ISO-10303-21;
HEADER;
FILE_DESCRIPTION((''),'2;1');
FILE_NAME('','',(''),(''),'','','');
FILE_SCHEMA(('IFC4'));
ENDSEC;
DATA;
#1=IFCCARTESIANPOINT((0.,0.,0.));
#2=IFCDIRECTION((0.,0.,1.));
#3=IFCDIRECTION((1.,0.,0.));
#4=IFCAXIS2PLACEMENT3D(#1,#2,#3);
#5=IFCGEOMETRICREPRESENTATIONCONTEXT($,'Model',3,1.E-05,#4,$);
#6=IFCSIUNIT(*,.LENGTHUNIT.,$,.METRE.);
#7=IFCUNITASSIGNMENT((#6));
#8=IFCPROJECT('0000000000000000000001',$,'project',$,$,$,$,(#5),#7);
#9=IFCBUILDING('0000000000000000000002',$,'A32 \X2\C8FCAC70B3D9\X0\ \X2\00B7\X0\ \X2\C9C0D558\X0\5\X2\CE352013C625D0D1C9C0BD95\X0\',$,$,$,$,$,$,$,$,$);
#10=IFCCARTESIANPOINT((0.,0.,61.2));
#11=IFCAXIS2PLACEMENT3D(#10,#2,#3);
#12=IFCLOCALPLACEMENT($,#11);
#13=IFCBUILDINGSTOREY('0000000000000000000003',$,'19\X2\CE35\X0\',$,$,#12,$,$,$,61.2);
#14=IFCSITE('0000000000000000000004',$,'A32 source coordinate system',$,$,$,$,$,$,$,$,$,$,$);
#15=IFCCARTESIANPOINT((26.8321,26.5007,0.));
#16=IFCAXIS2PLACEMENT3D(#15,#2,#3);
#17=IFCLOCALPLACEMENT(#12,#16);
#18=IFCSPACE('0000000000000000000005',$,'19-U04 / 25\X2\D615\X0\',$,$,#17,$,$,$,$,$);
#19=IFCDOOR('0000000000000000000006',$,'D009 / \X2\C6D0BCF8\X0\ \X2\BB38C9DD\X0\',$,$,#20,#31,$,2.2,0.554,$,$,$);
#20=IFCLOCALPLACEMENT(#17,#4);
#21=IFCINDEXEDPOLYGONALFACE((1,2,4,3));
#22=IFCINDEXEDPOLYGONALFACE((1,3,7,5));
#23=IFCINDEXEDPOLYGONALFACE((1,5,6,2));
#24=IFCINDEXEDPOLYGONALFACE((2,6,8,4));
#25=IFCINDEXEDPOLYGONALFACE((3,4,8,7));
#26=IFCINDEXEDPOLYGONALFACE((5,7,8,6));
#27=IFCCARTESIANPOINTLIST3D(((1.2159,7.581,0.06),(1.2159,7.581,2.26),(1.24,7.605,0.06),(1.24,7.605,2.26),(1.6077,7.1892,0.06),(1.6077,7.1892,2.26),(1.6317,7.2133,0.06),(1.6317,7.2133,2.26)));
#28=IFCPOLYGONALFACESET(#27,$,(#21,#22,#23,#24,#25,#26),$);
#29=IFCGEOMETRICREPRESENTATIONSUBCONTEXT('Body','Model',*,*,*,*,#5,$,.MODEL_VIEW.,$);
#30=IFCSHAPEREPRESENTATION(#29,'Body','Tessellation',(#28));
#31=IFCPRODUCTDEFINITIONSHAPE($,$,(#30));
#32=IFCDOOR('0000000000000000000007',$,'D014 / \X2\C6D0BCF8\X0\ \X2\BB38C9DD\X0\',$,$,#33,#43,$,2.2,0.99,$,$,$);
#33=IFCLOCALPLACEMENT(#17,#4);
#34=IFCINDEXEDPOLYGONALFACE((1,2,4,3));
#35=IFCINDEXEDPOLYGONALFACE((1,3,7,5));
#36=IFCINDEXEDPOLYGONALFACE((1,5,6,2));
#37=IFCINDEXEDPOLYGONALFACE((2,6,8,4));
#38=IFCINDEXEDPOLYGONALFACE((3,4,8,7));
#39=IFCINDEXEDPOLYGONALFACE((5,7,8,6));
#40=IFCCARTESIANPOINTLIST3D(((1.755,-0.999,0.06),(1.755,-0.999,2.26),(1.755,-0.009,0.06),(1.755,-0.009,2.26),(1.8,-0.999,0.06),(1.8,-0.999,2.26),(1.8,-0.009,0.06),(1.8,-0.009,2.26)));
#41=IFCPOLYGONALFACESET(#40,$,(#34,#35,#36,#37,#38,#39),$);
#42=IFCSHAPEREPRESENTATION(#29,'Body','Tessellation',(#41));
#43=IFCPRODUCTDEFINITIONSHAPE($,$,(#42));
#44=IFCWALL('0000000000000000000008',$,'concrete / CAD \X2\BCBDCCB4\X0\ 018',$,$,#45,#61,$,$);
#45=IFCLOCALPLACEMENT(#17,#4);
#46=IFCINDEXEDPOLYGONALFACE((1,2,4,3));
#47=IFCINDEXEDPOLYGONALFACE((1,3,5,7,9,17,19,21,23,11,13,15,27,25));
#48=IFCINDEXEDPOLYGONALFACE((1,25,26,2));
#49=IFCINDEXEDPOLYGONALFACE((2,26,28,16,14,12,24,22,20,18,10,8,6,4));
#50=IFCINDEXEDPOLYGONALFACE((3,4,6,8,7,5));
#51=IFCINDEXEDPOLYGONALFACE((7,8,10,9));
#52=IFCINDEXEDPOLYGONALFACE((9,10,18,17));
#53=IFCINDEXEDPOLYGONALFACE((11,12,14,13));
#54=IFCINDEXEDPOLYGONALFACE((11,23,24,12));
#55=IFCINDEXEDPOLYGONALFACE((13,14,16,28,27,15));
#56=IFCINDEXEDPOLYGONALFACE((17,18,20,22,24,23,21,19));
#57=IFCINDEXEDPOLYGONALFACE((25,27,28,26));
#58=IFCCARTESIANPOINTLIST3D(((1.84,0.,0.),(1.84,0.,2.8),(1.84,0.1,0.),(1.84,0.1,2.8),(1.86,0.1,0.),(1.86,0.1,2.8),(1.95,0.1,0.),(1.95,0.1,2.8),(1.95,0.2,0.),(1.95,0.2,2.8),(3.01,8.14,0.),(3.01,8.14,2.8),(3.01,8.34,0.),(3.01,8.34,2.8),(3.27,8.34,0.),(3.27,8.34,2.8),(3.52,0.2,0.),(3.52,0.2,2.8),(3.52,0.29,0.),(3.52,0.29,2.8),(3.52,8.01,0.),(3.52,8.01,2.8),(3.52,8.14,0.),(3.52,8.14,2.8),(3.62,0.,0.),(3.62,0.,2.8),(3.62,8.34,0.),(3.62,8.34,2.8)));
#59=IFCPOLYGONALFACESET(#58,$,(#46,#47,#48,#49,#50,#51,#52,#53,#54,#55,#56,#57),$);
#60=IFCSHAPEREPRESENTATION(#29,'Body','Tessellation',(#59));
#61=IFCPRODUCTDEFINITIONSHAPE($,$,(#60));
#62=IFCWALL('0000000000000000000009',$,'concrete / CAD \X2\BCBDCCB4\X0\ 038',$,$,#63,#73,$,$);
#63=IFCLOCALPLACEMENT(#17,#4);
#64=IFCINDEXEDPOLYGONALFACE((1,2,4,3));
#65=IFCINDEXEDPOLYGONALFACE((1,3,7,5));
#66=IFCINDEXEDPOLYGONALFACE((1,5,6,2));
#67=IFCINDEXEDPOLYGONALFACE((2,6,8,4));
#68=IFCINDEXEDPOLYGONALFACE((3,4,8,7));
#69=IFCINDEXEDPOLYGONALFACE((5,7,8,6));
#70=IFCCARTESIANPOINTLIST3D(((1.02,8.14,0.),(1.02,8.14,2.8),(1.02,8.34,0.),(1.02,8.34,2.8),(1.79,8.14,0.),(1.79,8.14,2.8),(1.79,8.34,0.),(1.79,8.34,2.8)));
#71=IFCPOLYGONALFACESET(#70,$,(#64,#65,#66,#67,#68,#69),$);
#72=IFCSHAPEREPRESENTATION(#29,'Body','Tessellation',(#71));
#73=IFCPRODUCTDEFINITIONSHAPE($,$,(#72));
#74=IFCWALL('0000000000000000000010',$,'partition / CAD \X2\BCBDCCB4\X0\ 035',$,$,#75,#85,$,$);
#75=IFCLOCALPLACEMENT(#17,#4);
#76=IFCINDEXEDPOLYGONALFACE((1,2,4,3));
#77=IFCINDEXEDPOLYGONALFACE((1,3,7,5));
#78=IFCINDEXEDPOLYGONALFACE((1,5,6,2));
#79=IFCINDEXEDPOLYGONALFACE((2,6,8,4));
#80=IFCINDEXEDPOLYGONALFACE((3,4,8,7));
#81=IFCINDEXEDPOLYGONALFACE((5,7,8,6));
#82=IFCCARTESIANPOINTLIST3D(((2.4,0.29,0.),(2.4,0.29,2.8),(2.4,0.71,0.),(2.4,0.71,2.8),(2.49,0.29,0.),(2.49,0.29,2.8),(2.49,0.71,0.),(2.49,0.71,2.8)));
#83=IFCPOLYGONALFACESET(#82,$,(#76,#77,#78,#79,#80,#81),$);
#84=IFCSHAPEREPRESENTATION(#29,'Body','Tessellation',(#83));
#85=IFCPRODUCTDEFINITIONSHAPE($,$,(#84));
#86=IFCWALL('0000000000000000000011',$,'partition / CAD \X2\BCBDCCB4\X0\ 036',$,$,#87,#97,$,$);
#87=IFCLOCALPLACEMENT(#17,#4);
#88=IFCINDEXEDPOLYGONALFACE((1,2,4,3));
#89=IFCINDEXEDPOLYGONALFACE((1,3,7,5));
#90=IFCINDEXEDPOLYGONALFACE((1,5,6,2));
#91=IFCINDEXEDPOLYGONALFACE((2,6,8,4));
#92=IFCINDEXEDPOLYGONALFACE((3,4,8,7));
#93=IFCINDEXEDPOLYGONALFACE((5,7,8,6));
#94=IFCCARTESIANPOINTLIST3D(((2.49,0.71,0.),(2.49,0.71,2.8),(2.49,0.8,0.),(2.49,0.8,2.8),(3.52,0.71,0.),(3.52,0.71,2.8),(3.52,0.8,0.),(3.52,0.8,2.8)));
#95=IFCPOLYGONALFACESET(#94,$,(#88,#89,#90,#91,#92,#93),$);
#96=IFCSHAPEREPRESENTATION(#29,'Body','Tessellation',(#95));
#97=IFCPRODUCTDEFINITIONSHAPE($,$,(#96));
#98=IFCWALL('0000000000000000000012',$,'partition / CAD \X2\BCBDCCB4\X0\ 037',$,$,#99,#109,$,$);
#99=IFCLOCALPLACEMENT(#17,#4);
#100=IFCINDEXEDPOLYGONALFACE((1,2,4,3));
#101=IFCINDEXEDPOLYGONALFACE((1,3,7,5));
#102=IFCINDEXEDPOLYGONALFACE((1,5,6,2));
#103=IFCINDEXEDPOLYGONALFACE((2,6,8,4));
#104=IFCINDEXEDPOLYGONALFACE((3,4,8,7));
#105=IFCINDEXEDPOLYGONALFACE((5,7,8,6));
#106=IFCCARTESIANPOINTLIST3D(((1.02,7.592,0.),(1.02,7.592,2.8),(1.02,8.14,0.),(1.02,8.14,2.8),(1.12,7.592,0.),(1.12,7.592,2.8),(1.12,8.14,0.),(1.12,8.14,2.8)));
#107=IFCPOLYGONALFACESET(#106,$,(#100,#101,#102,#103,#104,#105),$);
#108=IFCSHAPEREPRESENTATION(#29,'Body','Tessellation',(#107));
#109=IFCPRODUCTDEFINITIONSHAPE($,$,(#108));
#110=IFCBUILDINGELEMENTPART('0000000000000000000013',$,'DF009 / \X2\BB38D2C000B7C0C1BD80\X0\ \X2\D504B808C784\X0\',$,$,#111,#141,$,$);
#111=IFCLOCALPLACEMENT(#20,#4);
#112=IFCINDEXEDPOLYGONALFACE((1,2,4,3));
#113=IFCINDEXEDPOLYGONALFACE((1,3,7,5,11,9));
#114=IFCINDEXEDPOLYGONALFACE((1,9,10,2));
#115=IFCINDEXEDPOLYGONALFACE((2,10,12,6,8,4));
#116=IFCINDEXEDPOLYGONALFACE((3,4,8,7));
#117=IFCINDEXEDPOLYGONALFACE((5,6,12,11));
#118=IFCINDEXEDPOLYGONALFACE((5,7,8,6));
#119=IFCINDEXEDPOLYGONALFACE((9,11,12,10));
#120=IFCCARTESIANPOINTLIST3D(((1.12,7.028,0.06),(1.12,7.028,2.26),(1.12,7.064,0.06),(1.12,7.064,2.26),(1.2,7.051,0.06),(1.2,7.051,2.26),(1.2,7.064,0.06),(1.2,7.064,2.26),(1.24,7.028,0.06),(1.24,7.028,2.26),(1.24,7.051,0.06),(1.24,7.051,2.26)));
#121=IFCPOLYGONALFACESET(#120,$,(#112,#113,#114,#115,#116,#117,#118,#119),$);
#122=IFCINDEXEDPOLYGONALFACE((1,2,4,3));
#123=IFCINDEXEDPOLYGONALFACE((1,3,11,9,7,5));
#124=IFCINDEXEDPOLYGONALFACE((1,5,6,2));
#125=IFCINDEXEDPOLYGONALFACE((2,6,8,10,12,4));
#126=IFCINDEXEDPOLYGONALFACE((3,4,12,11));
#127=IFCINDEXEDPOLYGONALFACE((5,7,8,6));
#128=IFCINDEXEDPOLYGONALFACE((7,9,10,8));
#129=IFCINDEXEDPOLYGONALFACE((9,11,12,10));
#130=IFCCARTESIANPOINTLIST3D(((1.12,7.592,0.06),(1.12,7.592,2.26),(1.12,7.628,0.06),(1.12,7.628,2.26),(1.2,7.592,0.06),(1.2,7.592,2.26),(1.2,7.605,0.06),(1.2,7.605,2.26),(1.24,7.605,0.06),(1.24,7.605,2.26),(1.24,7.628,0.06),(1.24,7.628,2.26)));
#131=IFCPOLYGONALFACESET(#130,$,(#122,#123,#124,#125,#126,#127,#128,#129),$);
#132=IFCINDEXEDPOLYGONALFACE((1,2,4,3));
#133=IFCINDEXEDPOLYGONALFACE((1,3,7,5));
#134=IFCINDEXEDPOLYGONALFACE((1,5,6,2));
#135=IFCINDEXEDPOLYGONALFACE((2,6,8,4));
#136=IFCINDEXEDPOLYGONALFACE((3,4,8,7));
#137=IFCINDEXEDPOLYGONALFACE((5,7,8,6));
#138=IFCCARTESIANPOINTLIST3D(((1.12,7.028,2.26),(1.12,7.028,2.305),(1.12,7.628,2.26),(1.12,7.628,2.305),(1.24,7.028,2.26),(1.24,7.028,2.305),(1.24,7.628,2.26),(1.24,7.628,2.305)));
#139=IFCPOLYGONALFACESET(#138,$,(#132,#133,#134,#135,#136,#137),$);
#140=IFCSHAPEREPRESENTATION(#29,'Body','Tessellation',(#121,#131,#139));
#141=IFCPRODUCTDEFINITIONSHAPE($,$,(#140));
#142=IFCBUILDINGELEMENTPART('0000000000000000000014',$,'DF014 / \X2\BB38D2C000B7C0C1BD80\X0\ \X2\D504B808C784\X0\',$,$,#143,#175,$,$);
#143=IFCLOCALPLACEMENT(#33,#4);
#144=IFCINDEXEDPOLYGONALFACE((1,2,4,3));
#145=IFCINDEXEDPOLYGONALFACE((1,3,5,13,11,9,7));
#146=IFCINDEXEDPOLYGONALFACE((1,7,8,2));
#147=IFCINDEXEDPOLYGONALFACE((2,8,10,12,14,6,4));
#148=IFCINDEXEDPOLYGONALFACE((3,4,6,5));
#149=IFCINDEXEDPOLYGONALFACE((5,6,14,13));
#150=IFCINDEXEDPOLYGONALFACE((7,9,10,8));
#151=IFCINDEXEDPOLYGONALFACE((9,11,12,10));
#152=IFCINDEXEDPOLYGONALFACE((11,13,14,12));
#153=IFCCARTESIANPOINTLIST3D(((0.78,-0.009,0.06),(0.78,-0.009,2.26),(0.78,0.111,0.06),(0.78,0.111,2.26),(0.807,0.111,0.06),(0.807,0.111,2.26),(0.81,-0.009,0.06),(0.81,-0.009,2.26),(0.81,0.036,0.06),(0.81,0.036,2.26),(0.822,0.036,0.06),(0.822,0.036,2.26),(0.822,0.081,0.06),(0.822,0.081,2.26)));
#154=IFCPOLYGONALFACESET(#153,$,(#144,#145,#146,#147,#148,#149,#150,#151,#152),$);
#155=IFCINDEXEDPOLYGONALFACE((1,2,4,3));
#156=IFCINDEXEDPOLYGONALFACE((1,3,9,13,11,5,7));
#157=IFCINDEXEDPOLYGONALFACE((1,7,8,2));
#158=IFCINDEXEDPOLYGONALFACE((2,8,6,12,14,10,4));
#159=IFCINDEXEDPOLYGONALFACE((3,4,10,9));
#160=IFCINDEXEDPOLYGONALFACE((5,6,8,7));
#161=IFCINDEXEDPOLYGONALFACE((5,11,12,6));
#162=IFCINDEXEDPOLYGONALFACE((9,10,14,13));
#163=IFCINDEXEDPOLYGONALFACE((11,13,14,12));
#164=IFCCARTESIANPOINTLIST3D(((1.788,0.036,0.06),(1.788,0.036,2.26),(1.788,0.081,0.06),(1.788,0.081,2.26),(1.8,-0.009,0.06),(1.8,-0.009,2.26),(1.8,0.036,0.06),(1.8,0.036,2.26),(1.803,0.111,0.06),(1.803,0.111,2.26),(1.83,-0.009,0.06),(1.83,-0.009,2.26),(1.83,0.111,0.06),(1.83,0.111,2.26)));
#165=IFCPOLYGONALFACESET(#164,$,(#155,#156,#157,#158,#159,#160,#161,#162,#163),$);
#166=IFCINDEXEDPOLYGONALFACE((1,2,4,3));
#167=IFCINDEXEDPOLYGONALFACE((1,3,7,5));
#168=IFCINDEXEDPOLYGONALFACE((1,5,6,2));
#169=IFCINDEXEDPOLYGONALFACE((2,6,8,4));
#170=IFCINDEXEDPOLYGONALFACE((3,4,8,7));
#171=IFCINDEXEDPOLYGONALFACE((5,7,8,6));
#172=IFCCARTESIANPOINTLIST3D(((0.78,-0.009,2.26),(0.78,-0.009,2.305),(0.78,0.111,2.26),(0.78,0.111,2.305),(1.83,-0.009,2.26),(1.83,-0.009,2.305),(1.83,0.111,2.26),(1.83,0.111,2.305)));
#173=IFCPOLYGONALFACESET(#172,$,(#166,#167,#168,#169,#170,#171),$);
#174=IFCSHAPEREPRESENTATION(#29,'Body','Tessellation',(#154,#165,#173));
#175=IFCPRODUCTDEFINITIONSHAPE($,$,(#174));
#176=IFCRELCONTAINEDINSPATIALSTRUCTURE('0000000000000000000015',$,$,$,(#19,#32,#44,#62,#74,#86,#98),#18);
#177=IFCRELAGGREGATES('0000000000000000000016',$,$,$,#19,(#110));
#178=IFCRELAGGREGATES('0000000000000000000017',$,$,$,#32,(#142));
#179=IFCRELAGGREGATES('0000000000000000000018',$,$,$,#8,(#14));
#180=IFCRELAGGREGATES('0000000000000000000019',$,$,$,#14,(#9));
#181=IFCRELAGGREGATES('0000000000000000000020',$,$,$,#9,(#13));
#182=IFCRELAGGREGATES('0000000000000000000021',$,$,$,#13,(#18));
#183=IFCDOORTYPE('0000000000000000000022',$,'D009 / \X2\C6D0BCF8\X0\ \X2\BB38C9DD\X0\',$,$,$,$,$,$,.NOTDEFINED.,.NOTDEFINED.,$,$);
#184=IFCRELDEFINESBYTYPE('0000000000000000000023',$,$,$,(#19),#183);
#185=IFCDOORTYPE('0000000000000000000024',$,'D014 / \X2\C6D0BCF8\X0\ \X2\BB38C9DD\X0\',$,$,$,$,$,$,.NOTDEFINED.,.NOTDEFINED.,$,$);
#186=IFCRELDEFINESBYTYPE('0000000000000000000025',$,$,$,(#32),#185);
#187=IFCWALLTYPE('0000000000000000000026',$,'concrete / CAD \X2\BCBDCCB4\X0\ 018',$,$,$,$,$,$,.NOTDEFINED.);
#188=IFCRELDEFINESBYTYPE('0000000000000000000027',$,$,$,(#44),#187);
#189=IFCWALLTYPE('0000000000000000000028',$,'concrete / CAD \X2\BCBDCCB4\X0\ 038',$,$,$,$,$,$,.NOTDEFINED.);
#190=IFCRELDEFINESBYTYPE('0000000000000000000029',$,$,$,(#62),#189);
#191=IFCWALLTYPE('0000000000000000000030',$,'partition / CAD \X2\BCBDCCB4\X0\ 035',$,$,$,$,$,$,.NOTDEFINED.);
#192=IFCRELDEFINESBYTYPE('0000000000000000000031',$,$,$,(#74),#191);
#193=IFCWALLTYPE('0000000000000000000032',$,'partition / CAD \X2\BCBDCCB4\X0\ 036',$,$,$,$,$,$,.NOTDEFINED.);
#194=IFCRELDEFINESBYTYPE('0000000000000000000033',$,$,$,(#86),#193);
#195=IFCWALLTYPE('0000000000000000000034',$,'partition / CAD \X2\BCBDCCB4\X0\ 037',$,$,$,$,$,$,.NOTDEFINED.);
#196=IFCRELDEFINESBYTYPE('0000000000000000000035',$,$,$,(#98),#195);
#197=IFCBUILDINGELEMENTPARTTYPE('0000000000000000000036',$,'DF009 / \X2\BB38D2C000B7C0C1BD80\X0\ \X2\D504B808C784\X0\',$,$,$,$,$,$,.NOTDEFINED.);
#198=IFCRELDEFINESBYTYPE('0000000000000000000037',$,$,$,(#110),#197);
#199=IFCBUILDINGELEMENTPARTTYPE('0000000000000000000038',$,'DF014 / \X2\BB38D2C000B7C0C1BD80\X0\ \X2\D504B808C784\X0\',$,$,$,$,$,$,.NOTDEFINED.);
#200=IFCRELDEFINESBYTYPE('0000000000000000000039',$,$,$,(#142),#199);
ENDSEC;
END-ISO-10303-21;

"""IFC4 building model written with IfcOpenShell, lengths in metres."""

from ifc_helpers import new_model, si_unit, frame, origin, origin_with_axes, place, context, subcontext, project, spatial, polyline, outline, extrude, source, transform, mapped, type_object, type_shapes, element, aggregate, save


model = new_model("IFC4")

# Units and contexts
model_context = context("Model", 3, precision=1e-05, world=origin_with_axes())
body_context = subcontext(model_context, "Body", "Model", "MODEL_VIEW")
ifc_project = project(units=[si_unit("LENGTHUNIT", "METRE")], contexts=[model_context])

# Site, building, storey, space
storey_placement = place(None, frame((0.0, 0.0, 61.2), z_axis=(0.0, 0.0, 1.0), x_axis=(1.0, 0.0, 0.0)))
space_placement = place(storey_placement, frame((26.8321, 26.5007, 0.0), z_axis=(0.0, 0.0, 1.0), x_axis=(1.0, 0.0, 0.0)))
site = spatial("IfcSite", under=ifc_project, Name="A32 source coordinate system")
building = spatial("IfcBuilding", under=site, Name="A32 주거동 · 지하5층–옥탑지붕")
storey = spatial("IfcBuildingStorey", under=building, at=storey_placement, Name="19층", Elevation=61.2)
space = spatial("IfcSpace", under=storey, at=space_placement, Name="19-U04 / 25형")

# Doors
door_type_1 = type_object("IfcDoorType", Name="D009 / 원본 문짝", OperationType="NOTDEFINED", PredefinedType="NOTDEFINED")
shared_shape_1 = source(origin(), body_context, "Body", "SweptSolid", [
    extrude(outline(polyline([(1.24, 7.605), (1.6317, 7.2133), (1.6077, 7.1892), (1.2159, 7.581), (1.24, 7.605)])), frame((0.0, 0.0, 0.06)), (0.0, 0.0, 1.0), 2.2),
])
type_shapes(door_type_1, [shared_shape_1])
door_1_placement = place(space_placement, origin_with_axes())
door_1 = element("IfcDoor", 1, at=door_1_placement, inside=space, type_object=door_type_1, Name="D009 / 원본 문짝", OverallHeight=2.2, OverallWidth=0.554, context=body_context, shape_type="MappedRepresentation", body=[
    mapped(shared_shape_1, transform((0.0, 0.0, 0.0), scale=1.0)),
])
door_type_2 = type_object("IfcDoorType", Name="D014 / 원본 문짝", OperationType="NOTDEFINED", PredefinedType="NOTDEFINED")
shared_shape_2 = source(origin(), body_context, "Body", "SweptSolid", [
    extrude(outline(polyline([(1.8, -0.009), (1.8, -0.999), (1.755, -0.999), (1.755, -0.009), (1.8, -0.009)])), frame((0.0, 0.0, 0.06)), (0.0, 0.0, 1.0), 2.2),
])
type_shapes(door_type_2, [shared_shape_2])
door_2_placement = place(space_placement, origin_with_axes())
door_2 = element("IfcDoor", 2, at=door_2_placement, inside=space, type_object=door_type_2, Name="D014 / 원본 문짝", OverallHeight=2.2, OverallWidth=0.99, context=body_context, shape_type="MappedRepresentation", body=[
    mapped(shared_shape_2, transform((0.0, 0.0, 0.0), scale=1.0)),
])

# Walls
wall_type_1 = type_object("IfcWallType", Name="concrete / CAD 벽체 018", PredefinedType="NOTDEFINED")
shared_shape_3 = source(origin(), body_context, "Body", "SweptSolid", [
    extrude(outline(polyline([(3.27, 8.34), (3.27, 8.34), (3.62, 8.34), (3.62, 0.0), (1.84, 0.0), (1.84, 0.1), (1.86, 0.1), (1.95, 0.1), (1.95, 0.2), (3.52, 0.2), (3.52, 0.29), (3.52, 8.01), (3.52, 8.14), (3.01, 8.14), (3.01, 8.34), (3.27, 8.34)])), origin(), (0.0, 0.0, 1.0), 2.8),
])
type_shapes(wall_type_1, [shared_shape_3])
wall_1_placement = place(space_placement, origin_with_axes())
element("IfcWall", 3, at=wall_1_placement, inside=space, type_object=wall_type_1, Name="concrete / CAD 벽체 018", context=body_context, shape_type="MappedRepresentation", body=[
    mapped(shared_shape_3, transform((0.0, 0.0, 0.0), scale=1.0)),
])
wall_type_2 = type_object("IfcWallType", Name="concrete / CAD 벽체 038", PredefinedType="NOTDEFINED")
shared_shape_4 = source(origin(), body_context, "Body", "SweptSolid", [
    extrude(outline(polyline([(1.02, 8.14), (1.02, 8.34), (1.79, 8.34), (1.79, 8.14), (1.02, 8.14)])), origin(), (0.0, 0.0, 1.0), 2.8),
])
type_shapes(wall_type_2, [shared_shape_4])
wall_2_placement = place(space_placement, origin_with_axes())
element("IfcWall", 4, at=wall_2_placement, inside=space, type_object=wall_type_2, Name="concrete / CAD 벽체 038", context=body_context, shape_type="MappedRepresentation", body=[
    mapped(shared_shape_4, transform((0.0, 0.0, 0.0), scale=1.0)),
])
wall_type_3 = type_object("IfcWallType", Name="partition / CAD 벽체 035", PredefinedType="NOTDEFINED")
shared_shape_5 = source(origin(), body_context, "Body", "SweptSolid", [
    extrude(outline(polyline([(2.49, 0.71), (2.49, 0.29), (2.4, 0.29), (2.4, 0.71), (2.49, 0.71)])), origin(), (0.0, 0.0, 1.0), 2.8),
])
type_shapes(wall_type_3, [shared_shape_5])
wall_3_placement = place(space_placement, origin_with_axes())
element("IfcWall", 5, at=wall_3_placement, inside=space, type_object=wall_type_3, Name="partition / CAD 벽체 035", context=body_context, shape_type="MappedRepresentation", body=[
    mapped(shared_shape_5, transform((0.0, 0.0, 0.0), scale=1.0)),
])
wall_type_4 = type_object("IfcWallType", Name="partition / CAD 벽체 036", PredefinedType="NOTDEFINED")
shared_shape_6 = source(origin(), body_context, "Body", "SweptSolid", [
    extrude(outline(polyline([(2.49, 0.8), (3.52, 0.8), (3.52, 0.71), (2.49, 0.71), (2.49, 0.8)])), origin(), (0.0, 0.0, 1.0), 2.8),
])
type_shapes(wall_type_4, [shared_shape_6])
wall_4_placement = place(space_placement, origin_with_axes())
element("IfcWall", 6, at=wall_4_placement, inside=space, type_object=wall_type_4, Name="partition / CAD 벽체 036", context=body_context, shape_type="MappedRepresentation", body=[
    mapped(shared_shape_6, transform((0.0, 0.0, 0.0), scale=1.0)),
])
wall_type_5 = type_object("IfcWallType", Name="partition / CAD 벽체 037", PredefinedType="NOTDEFINED")
shared_shape_7 = source(origin(), body_context, "Body", "SweptSolid", [
    extrude(outline(polyline([(1.02, 7.592), (1.02, 8.14), (1.12, 8.14), (1.12, 7.592), (1.02, 7.592)])), origin(), (0.0, 0.0, 1.0), 2.8),
])
type_shapes(wall_type_5, [shared_shape_7])
wall_5_placement = place(space_placement, origin_with_axes())
element("IfcWall", 7, at=wall_5_placement, inside=space, type_object=wall_type_5, Name="partition / CAD 벽체 037", context=body_context, shape_type="MappedRepresentation", body=[
    mapped(shared_shape_7, transform((0.0, 0.0, 0.0), scale=1.0)),
])

# Building element parts
building_element_part_type_1 = type_object("IfcBuildingElementPartType", Name="DF009 / 문틀·상부 프레임", PredefinedType="NOTDEFINED")
shared_shape_8 = source(origin(), body_context, "Body", "SweptSolid", [
    extrude(outline(polyline([(1.12, 7.064), (1.2, 7.064), (1.2, 7.051), (1.24, 7.051), (1.24, 7.028), (1.12, 7.028), (1.12, 7.064)])), frame((0.0, 0.0, 0.06)), (0.0, 0.0, 1.0), 2.2),
    extrude(outline(polyline([(1.24, 7.628), (1.24, 7.605), (1.2, 7.605), (1.2, 7.592), (1.12, 7.592), (1.12, 7.628), (1.24, 7.628)])), frame((0.0, 0.0, 0.06)), (0.0, 0.0, 1.0), 2.2),
    extrude(outline(polyline([(1.12, 7.028), (1.12, 7.628), (1.24, 7.628), (1.24, 7.028), (1.12, 7.028)])), frame((0.0, 0.0, 2.26)), (0.0, 0.0, 1.0), 0.045),
])
type_shapes(building_element_part_type_1, [shared_shape_8])
building_element_part_1_placement = place(door_1_placement, origin_with_axes())
building_element_part_1 = element("IfcBuildingElementPart", 8, at=building_element_part_1_placement, type_object=building_element_part_type_1, Name="DF009 / 문틀·상부 프레임", context=body_context, shape_type="MappedRepresentation", body=[
    mapped(shared_shape_8, transform((0.0, 0.0, 0.0), scale=1.0)),
])
aggregate(door_1, [building_element_part_1])
building_element_part_type_2 = type_object("IfcBuildingElementPartType", Name="DF014 / 문틀·상부 프레임", PredefinedType="NOTDEFINED")
shared_shape_9 = source(origin(), body_context, "Body", "SweptSolid", [
    extrude(outline(polyline([(0.78, 0.111), (0.807, 0.111), (0.822, 0.081), (0.822, 0.036), (0.81, 0.036), (0.81, -0.009), (0.78, -0.009), (0.78, 0.111)])), frame((0.0, 0.0, 0.06)), (0.0, 0.0, 1.0), 2.2),
    extrude(outline(polyline([(1.8, -0.009), (1.8, 0.036), (1.788, 0.036), (1.788, 0.081), (1.803, 0.111), (1.83, 0.111), (1.83, -0.009), (1.8, -0.009)])), frame((0.0, 0.0, 0.06)), (0.0, 0.0, 1.0), 2.2),
    extrude(outline(polyline([(0.78, -0.009), (0.78, 0.111), (1.83, 0.111), (1.83, -0.009), (0.78, -0.009)])), frame((0.0, 0.0, 2.26)), (0.0, 0.0, 1.0), 0.045),
])
type_shapes(building_element_part_type_2, [shared_shape_9])
building_element_part_2_placement = place(door_2_placement, origin_with_axes())
building_element_part_2 = element("IfcBuildingElementPart", 9, at=building_element_part_2_placement, type_object=building_element_part_type_2, Name="DF014 / 문틀·상부 프레임", context=body_context, shape_type="MappedRepresentation", body=[
    mapped(shared_shape_9, transform((0.0, 0.0, 0.0), scale=1.0)),
])
aggregate(door_2, [building_element_part_2])

save(model, "model.ifc")
